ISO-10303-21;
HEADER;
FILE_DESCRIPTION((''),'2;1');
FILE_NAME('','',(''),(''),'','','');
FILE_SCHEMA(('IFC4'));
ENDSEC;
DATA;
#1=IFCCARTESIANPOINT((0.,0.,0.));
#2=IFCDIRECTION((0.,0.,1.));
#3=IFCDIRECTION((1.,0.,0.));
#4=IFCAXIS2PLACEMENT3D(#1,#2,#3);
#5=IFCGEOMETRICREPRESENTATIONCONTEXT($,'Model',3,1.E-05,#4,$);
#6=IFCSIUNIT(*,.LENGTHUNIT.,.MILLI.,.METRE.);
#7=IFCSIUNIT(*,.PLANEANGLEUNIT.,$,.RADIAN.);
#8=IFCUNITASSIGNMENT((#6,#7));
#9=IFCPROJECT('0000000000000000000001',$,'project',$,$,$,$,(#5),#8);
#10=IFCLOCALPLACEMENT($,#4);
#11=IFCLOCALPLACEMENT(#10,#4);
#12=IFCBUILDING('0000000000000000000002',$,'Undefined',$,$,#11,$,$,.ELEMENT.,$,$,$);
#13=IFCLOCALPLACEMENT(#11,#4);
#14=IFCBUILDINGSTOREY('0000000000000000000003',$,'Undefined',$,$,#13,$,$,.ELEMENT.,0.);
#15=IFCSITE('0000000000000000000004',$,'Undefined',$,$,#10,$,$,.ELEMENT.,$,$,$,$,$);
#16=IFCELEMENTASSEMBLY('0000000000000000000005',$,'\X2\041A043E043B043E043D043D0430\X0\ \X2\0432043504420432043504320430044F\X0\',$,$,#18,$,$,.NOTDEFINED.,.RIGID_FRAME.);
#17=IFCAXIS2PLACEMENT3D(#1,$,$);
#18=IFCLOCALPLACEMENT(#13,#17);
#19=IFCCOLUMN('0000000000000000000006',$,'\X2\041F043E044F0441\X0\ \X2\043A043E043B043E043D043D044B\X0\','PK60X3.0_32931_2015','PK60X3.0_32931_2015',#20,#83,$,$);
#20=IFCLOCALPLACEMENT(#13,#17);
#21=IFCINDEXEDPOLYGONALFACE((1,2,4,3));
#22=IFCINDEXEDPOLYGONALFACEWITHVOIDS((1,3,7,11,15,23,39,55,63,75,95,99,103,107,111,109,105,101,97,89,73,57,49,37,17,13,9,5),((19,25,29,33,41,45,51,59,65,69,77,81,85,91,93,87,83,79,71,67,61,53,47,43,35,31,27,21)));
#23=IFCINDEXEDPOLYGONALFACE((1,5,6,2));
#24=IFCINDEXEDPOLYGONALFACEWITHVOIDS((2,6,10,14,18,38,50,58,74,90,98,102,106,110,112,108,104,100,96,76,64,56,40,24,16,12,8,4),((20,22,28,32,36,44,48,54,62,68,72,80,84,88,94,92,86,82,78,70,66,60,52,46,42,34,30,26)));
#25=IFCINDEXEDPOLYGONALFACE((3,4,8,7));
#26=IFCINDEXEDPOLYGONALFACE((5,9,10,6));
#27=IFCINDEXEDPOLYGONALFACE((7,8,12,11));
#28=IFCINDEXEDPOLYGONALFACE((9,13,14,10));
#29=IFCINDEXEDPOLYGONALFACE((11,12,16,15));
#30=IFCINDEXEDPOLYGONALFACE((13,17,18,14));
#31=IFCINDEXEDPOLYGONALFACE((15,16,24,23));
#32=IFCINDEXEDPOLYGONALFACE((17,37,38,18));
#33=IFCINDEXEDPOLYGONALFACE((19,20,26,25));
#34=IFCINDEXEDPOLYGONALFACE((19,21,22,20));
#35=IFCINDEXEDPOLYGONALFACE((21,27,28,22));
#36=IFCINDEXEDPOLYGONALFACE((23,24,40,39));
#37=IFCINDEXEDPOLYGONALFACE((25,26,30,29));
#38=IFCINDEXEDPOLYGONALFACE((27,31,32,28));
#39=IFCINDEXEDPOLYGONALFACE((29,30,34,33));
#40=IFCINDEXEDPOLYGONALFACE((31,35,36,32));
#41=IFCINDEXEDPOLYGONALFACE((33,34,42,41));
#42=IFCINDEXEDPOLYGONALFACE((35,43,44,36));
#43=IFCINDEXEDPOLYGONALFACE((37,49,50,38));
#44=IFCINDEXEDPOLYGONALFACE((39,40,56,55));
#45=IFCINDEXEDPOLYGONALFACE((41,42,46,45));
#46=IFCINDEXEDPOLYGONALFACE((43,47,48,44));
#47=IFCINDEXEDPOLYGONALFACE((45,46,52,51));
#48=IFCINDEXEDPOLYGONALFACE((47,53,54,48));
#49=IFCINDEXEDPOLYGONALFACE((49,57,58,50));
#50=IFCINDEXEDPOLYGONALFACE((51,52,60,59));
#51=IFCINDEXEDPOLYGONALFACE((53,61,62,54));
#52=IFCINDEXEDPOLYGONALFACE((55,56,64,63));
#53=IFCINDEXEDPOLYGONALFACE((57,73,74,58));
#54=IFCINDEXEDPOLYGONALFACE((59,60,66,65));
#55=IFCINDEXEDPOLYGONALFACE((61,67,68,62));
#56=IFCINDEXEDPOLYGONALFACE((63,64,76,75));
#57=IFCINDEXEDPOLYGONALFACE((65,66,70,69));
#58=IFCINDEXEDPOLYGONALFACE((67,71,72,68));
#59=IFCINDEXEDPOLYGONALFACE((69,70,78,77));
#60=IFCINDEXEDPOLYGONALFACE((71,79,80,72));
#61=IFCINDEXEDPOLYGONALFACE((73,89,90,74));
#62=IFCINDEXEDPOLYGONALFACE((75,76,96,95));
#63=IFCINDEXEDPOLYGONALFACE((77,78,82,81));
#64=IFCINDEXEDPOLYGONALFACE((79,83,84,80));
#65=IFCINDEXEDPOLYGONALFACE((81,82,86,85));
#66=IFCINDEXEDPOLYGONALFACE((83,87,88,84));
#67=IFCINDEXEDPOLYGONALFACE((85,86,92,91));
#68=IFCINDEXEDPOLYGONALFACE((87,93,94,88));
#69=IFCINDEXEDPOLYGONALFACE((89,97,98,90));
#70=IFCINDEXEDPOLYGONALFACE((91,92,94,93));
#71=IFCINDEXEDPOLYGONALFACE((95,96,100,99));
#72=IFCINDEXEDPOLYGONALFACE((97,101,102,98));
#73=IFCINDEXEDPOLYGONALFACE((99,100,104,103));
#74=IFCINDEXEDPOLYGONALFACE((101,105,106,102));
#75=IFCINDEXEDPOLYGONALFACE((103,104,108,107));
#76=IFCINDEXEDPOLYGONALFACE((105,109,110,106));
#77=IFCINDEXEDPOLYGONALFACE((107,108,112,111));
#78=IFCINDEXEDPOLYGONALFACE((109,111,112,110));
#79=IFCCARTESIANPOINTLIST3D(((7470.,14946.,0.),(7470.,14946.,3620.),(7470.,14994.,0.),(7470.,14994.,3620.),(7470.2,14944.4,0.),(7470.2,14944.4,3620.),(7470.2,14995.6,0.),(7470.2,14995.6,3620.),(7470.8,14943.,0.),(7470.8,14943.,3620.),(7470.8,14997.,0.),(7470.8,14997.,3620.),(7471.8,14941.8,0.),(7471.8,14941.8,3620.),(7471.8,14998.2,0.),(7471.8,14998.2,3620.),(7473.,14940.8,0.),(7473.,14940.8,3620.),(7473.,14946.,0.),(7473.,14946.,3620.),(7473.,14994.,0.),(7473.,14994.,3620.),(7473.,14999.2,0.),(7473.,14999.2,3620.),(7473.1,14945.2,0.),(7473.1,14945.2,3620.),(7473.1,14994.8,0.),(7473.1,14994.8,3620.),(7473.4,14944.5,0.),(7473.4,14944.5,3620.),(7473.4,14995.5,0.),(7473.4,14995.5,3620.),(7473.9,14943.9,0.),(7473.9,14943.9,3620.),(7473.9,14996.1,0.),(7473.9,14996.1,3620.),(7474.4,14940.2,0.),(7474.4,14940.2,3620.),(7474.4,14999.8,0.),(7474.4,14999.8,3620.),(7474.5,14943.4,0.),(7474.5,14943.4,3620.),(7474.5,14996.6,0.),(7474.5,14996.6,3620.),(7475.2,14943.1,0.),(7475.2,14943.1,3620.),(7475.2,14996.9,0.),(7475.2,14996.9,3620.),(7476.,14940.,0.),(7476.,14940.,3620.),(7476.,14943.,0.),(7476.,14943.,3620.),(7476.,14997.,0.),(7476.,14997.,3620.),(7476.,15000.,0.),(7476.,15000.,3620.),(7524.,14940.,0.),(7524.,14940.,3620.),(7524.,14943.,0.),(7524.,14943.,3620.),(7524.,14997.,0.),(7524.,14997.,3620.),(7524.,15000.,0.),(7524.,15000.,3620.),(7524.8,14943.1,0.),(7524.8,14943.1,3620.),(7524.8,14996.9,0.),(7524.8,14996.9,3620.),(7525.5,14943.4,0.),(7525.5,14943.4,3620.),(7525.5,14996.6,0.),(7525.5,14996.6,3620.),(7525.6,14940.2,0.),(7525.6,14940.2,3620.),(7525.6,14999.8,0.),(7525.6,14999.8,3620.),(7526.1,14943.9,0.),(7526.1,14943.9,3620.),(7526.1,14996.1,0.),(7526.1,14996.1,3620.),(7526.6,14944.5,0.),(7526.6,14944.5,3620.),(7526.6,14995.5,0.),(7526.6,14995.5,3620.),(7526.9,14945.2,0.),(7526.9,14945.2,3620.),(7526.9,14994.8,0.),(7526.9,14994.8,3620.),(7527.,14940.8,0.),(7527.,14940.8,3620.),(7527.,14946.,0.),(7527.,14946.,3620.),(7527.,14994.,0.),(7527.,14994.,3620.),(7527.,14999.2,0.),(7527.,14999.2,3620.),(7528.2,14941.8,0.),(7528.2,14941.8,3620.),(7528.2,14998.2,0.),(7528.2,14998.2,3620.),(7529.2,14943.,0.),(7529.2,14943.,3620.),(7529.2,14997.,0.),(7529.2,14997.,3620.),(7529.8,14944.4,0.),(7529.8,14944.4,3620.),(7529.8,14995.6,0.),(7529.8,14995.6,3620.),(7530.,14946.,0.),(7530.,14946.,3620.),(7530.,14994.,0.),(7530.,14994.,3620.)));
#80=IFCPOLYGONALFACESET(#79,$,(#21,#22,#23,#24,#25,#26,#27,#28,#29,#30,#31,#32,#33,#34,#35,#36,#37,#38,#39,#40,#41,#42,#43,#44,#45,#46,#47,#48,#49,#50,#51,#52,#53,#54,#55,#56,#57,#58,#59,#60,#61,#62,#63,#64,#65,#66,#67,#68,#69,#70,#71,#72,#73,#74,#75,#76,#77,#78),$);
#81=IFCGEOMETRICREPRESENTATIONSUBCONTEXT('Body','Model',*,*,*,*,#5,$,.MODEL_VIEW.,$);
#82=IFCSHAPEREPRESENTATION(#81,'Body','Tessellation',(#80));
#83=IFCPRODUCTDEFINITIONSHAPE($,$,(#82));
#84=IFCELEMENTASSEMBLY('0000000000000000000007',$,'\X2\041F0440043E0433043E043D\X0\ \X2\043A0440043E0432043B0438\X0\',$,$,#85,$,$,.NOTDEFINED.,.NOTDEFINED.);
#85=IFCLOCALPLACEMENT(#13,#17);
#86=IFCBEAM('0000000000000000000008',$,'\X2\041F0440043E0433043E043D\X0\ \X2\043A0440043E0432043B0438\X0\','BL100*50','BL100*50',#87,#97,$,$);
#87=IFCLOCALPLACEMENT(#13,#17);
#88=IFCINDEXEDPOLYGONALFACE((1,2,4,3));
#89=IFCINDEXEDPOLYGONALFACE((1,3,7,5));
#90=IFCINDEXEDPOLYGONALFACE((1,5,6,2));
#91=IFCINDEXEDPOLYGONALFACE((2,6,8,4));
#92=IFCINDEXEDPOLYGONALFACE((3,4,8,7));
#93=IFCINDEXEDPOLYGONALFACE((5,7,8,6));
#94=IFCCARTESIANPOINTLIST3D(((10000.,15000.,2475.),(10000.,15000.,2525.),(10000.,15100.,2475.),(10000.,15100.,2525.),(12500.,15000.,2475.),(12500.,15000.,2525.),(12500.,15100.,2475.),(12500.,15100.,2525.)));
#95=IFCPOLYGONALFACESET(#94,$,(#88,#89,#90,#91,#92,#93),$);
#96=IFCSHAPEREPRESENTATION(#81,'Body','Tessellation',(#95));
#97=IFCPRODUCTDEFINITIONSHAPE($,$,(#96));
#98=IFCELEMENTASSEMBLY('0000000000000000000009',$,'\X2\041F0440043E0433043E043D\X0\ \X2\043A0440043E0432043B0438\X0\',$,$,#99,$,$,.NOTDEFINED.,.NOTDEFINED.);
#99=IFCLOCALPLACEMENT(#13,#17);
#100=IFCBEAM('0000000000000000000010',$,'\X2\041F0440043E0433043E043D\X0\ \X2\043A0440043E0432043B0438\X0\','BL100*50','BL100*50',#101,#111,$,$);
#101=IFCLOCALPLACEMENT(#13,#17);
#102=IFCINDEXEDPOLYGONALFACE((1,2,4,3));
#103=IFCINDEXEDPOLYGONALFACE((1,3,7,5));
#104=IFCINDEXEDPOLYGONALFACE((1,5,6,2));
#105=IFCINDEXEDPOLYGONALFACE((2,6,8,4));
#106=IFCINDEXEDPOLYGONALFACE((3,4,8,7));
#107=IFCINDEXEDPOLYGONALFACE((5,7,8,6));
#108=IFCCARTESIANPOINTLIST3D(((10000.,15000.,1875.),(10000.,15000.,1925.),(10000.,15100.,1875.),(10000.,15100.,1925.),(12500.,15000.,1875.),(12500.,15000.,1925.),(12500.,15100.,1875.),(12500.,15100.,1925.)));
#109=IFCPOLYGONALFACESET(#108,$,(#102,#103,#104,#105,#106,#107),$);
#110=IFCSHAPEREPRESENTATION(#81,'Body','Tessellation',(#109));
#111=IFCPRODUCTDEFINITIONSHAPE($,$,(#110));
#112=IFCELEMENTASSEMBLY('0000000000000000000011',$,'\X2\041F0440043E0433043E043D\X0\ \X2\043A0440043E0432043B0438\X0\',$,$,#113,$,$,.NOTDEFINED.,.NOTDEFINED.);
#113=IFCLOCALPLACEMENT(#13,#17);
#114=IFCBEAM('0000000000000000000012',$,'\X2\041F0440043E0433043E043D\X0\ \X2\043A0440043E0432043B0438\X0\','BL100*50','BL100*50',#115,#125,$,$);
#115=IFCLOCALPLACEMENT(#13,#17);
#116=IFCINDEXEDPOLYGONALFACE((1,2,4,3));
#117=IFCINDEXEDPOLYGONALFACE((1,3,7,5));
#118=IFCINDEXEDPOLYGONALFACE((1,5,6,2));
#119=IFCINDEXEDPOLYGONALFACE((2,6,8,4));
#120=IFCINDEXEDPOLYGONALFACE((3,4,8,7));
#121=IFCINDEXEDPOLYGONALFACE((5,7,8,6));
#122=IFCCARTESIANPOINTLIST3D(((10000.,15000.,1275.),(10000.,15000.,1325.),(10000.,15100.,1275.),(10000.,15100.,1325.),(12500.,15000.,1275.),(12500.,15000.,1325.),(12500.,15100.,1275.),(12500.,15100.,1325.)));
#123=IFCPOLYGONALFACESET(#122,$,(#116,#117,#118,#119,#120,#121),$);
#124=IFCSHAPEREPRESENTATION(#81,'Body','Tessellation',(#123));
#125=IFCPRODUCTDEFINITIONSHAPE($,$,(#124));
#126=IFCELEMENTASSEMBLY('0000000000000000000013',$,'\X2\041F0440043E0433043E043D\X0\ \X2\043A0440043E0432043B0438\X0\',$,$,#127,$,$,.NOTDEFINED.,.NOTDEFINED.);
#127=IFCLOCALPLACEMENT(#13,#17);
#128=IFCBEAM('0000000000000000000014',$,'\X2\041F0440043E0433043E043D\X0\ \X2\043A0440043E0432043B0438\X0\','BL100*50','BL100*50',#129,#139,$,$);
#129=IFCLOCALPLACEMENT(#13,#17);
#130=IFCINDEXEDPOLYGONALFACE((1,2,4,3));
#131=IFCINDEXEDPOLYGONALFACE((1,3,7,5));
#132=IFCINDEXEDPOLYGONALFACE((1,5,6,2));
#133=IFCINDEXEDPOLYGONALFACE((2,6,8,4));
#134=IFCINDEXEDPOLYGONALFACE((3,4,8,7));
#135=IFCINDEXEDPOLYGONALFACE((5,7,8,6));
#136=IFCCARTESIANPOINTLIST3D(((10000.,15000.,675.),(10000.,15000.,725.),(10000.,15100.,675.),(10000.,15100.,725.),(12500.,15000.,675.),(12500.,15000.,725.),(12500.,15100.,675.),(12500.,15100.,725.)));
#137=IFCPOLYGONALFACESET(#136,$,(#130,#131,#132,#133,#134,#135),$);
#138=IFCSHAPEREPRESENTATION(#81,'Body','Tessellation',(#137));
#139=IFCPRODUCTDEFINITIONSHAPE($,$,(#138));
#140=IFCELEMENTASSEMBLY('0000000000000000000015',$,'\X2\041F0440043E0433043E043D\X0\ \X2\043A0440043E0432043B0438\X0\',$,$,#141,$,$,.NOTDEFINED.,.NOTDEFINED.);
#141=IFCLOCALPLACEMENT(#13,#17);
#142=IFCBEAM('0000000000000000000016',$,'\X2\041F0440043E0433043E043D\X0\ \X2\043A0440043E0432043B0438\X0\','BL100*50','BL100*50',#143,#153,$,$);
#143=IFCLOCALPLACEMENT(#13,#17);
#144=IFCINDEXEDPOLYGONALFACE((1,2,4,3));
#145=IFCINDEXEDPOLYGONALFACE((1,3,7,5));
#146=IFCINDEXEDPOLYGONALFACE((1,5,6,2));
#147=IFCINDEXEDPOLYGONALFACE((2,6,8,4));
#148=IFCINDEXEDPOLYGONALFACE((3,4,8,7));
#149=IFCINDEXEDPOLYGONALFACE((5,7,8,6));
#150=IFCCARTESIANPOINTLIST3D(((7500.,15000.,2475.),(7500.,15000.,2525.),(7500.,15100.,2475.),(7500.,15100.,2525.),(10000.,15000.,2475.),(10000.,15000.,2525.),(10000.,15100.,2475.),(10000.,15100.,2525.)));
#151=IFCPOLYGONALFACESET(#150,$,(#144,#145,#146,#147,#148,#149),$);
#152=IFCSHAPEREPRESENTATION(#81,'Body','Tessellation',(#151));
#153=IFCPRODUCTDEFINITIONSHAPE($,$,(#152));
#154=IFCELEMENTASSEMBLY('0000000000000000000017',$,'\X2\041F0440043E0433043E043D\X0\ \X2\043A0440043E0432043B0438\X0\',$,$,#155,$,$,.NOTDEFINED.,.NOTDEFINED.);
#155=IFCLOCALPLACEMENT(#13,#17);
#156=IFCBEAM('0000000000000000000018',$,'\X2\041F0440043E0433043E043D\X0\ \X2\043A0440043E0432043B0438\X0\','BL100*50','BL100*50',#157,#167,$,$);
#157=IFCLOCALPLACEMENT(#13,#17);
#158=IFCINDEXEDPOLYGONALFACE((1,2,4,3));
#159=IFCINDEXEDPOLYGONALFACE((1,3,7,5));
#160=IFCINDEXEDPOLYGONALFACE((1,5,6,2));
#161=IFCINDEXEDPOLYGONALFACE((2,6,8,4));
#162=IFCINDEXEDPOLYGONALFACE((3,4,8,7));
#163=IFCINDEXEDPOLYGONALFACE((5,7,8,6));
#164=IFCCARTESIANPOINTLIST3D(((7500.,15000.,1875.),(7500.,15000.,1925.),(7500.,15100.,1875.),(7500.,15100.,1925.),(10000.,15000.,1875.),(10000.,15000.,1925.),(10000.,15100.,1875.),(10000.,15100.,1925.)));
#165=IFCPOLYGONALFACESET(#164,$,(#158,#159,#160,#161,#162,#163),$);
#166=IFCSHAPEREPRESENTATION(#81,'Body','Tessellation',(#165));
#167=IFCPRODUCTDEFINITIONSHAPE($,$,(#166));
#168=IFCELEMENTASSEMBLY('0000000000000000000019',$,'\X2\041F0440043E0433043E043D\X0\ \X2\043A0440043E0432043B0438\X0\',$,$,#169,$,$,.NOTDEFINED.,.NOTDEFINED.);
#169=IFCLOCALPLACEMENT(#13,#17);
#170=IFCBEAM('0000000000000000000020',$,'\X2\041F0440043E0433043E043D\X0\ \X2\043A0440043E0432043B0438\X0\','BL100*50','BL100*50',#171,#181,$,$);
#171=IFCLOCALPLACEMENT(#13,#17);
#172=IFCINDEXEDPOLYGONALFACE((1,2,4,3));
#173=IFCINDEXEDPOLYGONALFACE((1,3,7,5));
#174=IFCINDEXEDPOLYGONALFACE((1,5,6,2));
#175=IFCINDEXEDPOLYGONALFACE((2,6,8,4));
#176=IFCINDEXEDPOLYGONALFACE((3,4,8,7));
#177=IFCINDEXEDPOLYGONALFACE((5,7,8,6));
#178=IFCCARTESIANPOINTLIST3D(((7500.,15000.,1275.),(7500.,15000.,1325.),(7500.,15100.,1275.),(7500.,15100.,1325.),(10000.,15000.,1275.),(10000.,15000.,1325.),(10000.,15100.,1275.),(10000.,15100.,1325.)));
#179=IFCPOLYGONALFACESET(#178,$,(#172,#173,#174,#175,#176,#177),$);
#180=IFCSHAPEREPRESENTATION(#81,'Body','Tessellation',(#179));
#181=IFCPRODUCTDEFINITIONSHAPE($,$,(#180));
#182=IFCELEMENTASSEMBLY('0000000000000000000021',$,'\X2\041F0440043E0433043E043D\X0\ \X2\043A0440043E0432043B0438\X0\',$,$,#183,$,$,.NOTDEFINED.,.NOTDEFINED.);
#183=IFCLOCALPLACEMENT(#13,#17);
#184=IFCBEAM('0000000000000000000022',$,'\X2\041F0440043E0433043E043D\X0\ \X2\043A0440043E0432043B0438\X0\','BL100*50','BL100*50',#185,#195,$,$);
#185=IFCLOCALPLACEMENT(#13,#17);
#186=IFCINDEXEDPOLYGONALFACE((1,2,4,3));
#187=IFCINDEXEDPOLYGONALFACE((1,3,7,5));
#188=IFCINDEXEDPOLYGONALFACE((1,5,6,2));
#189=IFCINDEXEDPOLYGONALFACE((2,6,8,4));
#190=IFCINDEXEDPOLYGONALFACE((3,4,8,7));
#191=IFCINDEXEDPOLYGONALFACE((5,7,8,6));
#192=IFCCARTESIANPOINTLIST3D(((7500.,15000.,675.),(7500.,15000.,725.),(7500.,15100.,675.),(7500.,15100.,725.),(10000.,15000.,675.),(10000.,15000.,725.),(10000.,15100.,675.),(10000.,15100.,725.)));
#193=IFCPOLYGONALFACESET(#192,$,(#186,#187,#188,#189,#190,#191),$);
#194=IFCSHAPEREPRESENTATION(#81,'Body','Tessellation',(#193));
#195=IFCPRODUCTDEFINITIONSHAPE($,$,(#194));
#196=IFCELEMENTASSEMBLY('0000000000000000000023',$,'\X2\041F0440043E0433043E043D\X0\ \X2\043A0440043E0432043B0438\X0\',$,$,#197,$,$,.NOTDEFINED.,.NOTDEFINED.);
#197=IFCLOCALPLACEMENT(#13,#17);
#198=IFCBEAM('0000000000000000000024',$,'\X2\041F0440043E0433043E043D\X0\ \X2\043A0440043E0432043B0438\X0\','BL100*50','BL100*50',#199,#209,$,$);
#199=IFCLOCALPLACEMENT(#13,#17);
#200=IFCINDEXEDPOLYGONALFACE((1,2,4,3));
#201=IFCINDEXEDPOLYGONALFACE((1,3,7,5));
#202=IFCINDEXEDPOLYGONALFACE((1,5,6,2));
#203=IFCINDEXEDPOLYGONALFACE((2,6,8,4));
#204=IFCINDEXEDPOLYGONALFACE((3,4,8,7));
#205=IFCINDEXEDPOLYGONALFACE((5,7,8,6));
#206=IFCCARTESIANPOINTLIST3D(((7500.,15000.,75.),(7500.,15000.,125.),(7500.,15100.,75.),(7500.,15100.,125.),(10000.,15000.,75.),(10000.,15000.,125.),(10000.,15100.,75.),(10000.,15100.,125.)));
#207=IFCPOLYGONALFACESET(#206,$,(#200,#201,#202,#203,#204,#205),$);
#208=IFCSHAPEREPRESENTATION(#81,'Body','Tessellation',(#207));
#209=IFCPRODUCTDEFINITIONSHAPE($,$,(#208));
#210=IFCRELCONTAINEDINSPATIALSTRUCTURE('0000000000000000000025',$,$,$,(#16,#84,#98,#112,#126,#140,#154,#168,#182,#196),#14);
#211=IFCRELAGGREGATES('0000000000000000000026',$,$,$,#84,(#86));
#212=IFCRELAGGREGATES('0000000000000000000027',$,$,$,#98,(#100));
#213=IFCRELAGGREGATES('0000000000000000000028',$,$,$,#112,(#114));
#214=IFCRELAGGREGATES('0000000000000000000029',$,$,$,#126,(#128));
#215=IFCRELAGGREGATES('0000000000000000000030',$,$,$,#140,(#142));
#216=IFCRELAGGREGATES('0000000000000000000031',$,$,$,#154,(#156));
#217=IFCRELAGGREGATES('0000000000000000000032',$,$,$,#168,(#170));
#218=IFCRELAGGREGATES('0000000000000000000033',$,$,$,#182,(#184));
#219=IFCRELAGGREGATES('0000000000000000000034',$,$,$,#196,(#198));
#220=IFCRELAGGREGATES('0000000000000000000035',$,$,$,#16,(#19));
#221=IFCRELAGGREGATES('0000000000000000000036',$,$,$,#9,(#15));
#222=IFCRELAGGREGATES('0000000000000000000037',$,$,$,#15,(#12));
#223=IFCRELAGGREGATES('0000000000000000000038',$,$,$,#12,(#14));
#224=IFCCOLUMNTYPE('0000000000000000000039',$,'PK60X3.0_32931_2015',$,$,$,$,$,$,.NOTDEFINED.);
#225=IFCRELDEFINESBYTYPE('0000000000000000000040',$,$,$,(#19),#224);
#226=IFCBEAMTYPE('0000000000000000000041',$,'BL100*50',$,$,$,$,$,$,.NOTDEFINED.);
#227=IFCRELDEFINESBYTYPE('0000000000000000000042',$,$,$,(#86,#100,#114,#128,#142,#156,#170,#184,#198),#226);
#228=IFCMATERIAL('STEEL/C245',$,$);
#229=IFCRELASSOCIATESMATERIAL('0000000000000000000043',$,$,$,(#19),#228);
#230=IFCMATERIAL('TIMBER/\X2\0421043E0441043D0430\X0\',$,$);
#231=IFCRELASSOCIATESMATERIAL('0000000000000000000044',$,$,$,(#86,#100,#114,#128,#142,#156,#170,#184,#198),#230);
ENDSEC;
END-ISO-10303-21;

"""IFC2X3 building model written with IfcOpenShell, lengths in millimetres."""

from ifc_helpers import new_model, si_unit, frame, origin_with_axes, origin_2d_with_axis, place, context, subcontext, project, spatial, rectangle, hollow_rectangle, extrude, material, type_object, element, aggregate, save


model = new_model("IFC2X3")

# Units and contexts
model_context = context("Model", 3, precision=1e-05, world=origin_with_axes())
body_context = subcontext(model_context, "Body", "Model", "MODEL_VIEW")
ifc_project = project(units=[si_unit("LENGTHUNIT", "METRE", prefix="MILLI"), si_unit("PLANEANGLEUNIT", "RADIAN")], contexts=[model_context])

# Site, building, storey
site_placement = place(None, origin_with_axes())
site = spatial("IfcSite", under=ifc_project, at=site_placement, Name="Undefined", CompositionType="ELEMENT")
building_placement = place(site_placement, origin_with_axes())
building = spatial("IfcBuilding", under=site, at=building_placement, Name="Undefined", CompositionType="ELEMENT")
storey_placement = place(building_placement, origin_with_axes())
storey = spatial("IfcBuildingStorey", under=building, at=storey_placement, Name="Undefined", CompositionType="ELEMENT", Elevation=0.0)

# Shared definitions
ifc_material_1 = material(Name="STEEL/C245")
column_type = type_object("IfcColumnType", Name="PK60X3.0_32931_2015", PredefinedType="NOTDEFINED")

# Element assembly, column
assembly_1_placement = place(storey_placement, origin_with_axes())
assembly_1 = element("IfcElementAssembly", 1, at=assembly_1_placement, inside=storey, Name="Колонна ветвевая", AssemblyPlace="NOTDEFINED", PredefinedType="RIGID_FRAME")
column_1_placement = place(assembly_1_placement, frame((7500.0, 14970.0, 0.0), z_axis=(0.0, 0.0, 1.0), x_axis=(-1.0, 0.0, 0.0)))
column_1 = element("IfcColumn", 2, at=column_1_placement, type_object=column_type, material=ifc_material_1, Name="Пояс колонны", Description="PK60X3.0_32931_2015", ObjectType="PK60X3.0_32931_2015", context=body_context, shape_type="SweptSolid", body=[
    extrude(hollow_rectangle(XDim=60.0, YDim=60.0, WallThickness=3.0, InnerFilletRadius=3.0, OuterFilletRadius=6.0, at=origin_2d_with_axis()), frame((0.0, 0.0, 3620.0), z_axis=(0.0, 0.0, -1.0), x_axis=(0.0, 1.0, 0.0)), (0.0, 0.0, 1.0), 3620.0),
])

# Element assemblies, beams
assembly_2_placement = place(storey_placement, origin_with_axes())
assembly_2 = element("IfcElementAssembly", 3, at=assembly_2_placement, inside=storey, Name="Прогон кровли", AssemblyPlace="NOTDEFINED", PredefinedType="NOTDEFINED")
ifc_material_2 = material(Name="TIMBER/Сосна")
beam_type_1 = type_object("IfcBeamType", Name="BL100*50", PredefinedType="NOTDEFINED")
beam_1_placement = place(assembly_2_placement, frame((10000.0, 15050.0, 2500.0), z_axis=(0.0, 1.0, 0.0), x_axis=(1.0, 0.0, 0.0)))
beam_1 = element("IfcBeam", 4, at=beam_1_placement, type_object=beam_type_1, material=ifc_material_2, Name="Прогон кровли", Description="BL100*50", ObjectType="BL100*50", context=body_context, shape_type="SweptSolid", body=[
    extrude(rectangle(XDim=50.0, YDim=100.0, at=origin_2d_with_axis()), frame((2500.0, 0.0, 0.0), z_axis=(-1.0, 0.0, 0.0), x_axis=(0.0, -1.0, 0.0)), (0.0, 0.0, 1.0), 2500.0),
])
aggregate(assembly_2, [beam_1])
assembly_3_placement = place(storey_placement, origin_with_axes())
assembly_3 = element("IfcElementAssembly", 5, at=assembly_3_placement, inside=storey, Name="Прогон кровли", AssemblyPlace="NOTDEFINED", PredefinedType="NOTDEFINED")
beam_2_placement = place(assembly_3_placement, frame((10000.0, 15050.0, 1900.0), z_axis=(0.0, 1.0, 0.0), x_axis=(1.0, 0.0, 0.0)))
beam_2 = element("IfcBeam", 6, at=beam_2_placement, type_object=beam_type_1, material=ifc_material_2, Name="Прогон кровли", Description="BL100*50", ObjectType="BL100*50", context=body_context, shape_type="SweptSolid", body=[
    extrude(rectangle(XDim=50.0, YDim=100.0, at=origin_2d_with_axis()), frame((2500.0, 0.0, 0.0), z_axis=(-1.0, 0.0, 0.0), x_axis=(0.0, -1.0, 0.0)), (0.0, 0.0, 1.0), 2500.0),
])
aggregate(assembly_3, [beam_2])
assembly_4_placement = place(storey_placement, origin_with_axes())
assembly_4 = element("IfcElementAssembly", 7, at=assembly_4_placement, inside=storey, Name="Прогон кровли", AssemblyPlace="NOTDEFINED", PredefinedType="NOTDEFINED")
beam_3_placement = place(assembly_4_placement, frame((10000.0, 15050.0, 1300.0), z_axis=(0.0, 1.0, 0.0), x_axis=(1.0, 0.0, 0.0)))
beam_3 = element("IfcBeam", 8, at=beam_3_placement, type_object=beam_type_1, material=ifc_material_2, Name="Прогон кровли", Description="BL100*50", ObjectType="BL100*50", context=body_context, shape_type="SweptSolid", body=[
    extrude(rectangle(XDim=50.0, YDim=100.0, at=origin_2d_with_axis()), frame((2500.0, 0.0, 0.0), z_axis=(-1.0, 0.0, 0.0), x_axis=(0.0, -1.0, 0.0)), (0.0, 0.0, 1.0), 2500.0),
])
aggregate(assembly_4, [beam_3])
assembly_5_placement = place(storey_placement, origin_with_axes())
assembly_5 = element("IfcElementAssembly", 9, at=assembly_5_placement, inside=storey, Name="Прогон кровли", AssemblyPlace="NOTDEFINED", PredefinedType="NOTDEFINED")
beam_4_placement = place(assembly_5_placement, frame((10000.0, 15050.0, 700.0), z_axis=(0.0, 1.0, 0.0), x_axis=(1.0, 0.0, 0.0)))
beam_4 = element("IfcBeam", 10, at=beam_4_placement, type_object=beam_type_1, material=ifc_material_2, Name="Прогон кровли", Description="BL100*50", ObjectType="BL100*50", context=body_context, shape_type="SweptSolid", body=[
    extrude(rectangle(XDim=50.0, YDim=100.0, at=origin_2d_with_axis()), frame((2500.0, 0.0, 0.0), z_axis=(-1.0, 0.0, 0.0), x_axis=(0.0, -1.0, 0.0)), (0.0, 0.0, 1.0), 2500.0),
])
aggregate(assembly_5, [beam_4])
assembly_6_placement = place(storey_placement, origin_with_axes())
assembly_6 = element("IfcElementAssembly", 11, at=assembly_6_placement, inside=storey, Name="Прогон кровли", AssemblyPlace="NOTDEFINED", PredefinedType="NOTDEFINED")
beam_5_placement = place(assembly_6_placement, frame((7500.0, 15050.0, 2500.0), z_axis=(0.0, 1.0, 0.0), x_axis=(1.0, 0.0, 0.0)))
beam_5 = element("IfcBeam", 12, at=beam_5_placement, type_object=beam_type_1, material=ifc_material_2, Name="Прогон кровли", Description="BL100*50", ObjectType="BL100*50", context=body_context, shape_type="SweptSolid", body=[
    extrude(rectangle(XDim=50.0, YDim=100.0, at=origin_2d_with_axis()), frame((2500.0, 0.0, 0.0), z_axis=(-1.0, 0.0, 0.0), x_axis=(0.0, -1.0, 0.0)), (0.0, 0.0, 1.0), 2500.0),
])
aggregate(assembly_6, [beam_5])
assembly_7_placement = place(storey_placement, origin_with_axes())
assembly_7 = element("IfcElementAssembly", 13, at=assembly_7_placement, inside=storey, Name="Прогон кровли", AssemblyPlace="NOTDEFINED", PredefinedType="NOTDEFINED")
beam_6_placement = place(assembly_7_placement, frame((7500.0, 15050.0, 1900.0), z_axis=(0.0, 1.0, 0.0), x_axis=(1.0, 0.0, 0.0)))
beam_6 = element("IfcBeam", 14, at=beam_6_placement, type_object=beam_type_1, material=ifc_material_2, Name="Прогон кровли", Description="BL100*50", ObjectType="BL100*50", context=body_context, shape_type="SweptSolid", body=[
    extrude(rectangle(XDim=50.0, YDim=100.0, at=origin_2d_with_axis()), frame((2500.0, 0.0, 0.0), z_axis=(-1.0, 0.0, 0.0), x_axis=(0.0, -1.0, 0.0)), (0.0, 0.0, 1.0), 2500.0),
])
aggregate(assembly_7, [beam_6])
assembly_8_placement = place(storey_placement, origin_with_axes())
assembly_8 = element("IfcElementAssembly", 15, at=assembly_8_placement, inside=storey, Name="Прогон кровли", AssemblyPlace="NOTDEFINED", PredefinedType="NOTDEFINED")
beam_7_placement = place(assembly_8_placement, frame((7500.0, 15050.0, 1300.0), z_axis=(0.0, 1.0, 0.0), x_axis=(1.0, 0.0, 0.0)))
beam_7 = element("IfcBeam", 16, at=beam_7_placement, type_object=beam_type_1, material=ifc_material_2, Name="Прогон кровли", Description="BL100*50", ObjectType="BL100*50", context=body_context, shape_type="SweptSolid", body=[
    extrude(rectangle(XDim=50.0, YDim=100.0, at=origin_2d_with_axis()), frame((2500.0, 0.0, 0.0), z_axis=(-1.0, 0.0, 0.0), x_axis=(0.0, -1.0, 0.0)), (0.0, 0.0, 1.0), 2500.0),
])
aggregate(assembly_8, [beam_7])
assembly_9_placement = place(storey_placement, origin_with_axes())
assembly_9 = element("IfcElementAssembly", 17, at=assembly_9_placement, inside=storey, Name="Прогон кровли", AssemblyPlace="NOTDEFINED", PredefinedType="NOTDEFINED")
beam_8_placement = place(assembly_9_placement, frame((7500.0, 15050.0, 700.0), z_axis=(0.0, 1.0, 0.0), x_axis=(1.0, 0.0, 0.0)))
beam_8 = element("IfcBeam", 18, at=beam_8_placement, type_object=beam_type_1, material=ifc_material_2, Name="Прогон кровли", Description="BL100*50", ObjectType="BL100*50", context=body_context, shape_type="SweptSolid", body=[
    extrude(rectangle(XDim=50.0, YDim=100.0, at=origin_2d_with_axis()), frame((2500.0, 0.0, 0.0), z_axis=(-1.0, 0.0, 0.0), x_axis=(0.0, -1.0, 0.0)), (0.0, 0.0, 1.0), 2500.0),
])
aggregate(assembly_9, [beam_8])
assembly_10_placement = place(storey_placement, origin_with_axes())
assembly_10 = element("IfcElementAssembly", 19, at=assembly_10_placement, inside=storey, Name="Прогон кровли", AssemblyPlace="NOTDEFINED", PredefinedType="NOTDEFINED")
beam_9_placement = place(assembly_10_placement, frame((7500.0, 15050.0, 100.0), z_axis=(0.0, 1.0, 0.0), x_axis=(1.0, 0.0, 0.0)))
beam_9 = element("IfcBeam", 20, at=beam_9_placement, type_object=beam_type_1, material=ifc_material_2, Name="Прогон кровли", Description="BL100*50", ObjectType="BL100*50", context=body_context, shape_type="SweptSolid", body=[
    extrude(rectangle(XDim=50.0, YDim=100.0, at=origin_2d_with_axis()), frame((2500.0, 0.0, 0.0), z_axis=(-1.0, 0.0, 0.0), x_axis=(0.0, -1.0, 0.0)), (0.0, 0.0, 1.0), 2500.0),
])
aggregate(assembly_10, [beam_9])

aggregate(assembly_1, [column_1])

save(model, "model.ifc")
